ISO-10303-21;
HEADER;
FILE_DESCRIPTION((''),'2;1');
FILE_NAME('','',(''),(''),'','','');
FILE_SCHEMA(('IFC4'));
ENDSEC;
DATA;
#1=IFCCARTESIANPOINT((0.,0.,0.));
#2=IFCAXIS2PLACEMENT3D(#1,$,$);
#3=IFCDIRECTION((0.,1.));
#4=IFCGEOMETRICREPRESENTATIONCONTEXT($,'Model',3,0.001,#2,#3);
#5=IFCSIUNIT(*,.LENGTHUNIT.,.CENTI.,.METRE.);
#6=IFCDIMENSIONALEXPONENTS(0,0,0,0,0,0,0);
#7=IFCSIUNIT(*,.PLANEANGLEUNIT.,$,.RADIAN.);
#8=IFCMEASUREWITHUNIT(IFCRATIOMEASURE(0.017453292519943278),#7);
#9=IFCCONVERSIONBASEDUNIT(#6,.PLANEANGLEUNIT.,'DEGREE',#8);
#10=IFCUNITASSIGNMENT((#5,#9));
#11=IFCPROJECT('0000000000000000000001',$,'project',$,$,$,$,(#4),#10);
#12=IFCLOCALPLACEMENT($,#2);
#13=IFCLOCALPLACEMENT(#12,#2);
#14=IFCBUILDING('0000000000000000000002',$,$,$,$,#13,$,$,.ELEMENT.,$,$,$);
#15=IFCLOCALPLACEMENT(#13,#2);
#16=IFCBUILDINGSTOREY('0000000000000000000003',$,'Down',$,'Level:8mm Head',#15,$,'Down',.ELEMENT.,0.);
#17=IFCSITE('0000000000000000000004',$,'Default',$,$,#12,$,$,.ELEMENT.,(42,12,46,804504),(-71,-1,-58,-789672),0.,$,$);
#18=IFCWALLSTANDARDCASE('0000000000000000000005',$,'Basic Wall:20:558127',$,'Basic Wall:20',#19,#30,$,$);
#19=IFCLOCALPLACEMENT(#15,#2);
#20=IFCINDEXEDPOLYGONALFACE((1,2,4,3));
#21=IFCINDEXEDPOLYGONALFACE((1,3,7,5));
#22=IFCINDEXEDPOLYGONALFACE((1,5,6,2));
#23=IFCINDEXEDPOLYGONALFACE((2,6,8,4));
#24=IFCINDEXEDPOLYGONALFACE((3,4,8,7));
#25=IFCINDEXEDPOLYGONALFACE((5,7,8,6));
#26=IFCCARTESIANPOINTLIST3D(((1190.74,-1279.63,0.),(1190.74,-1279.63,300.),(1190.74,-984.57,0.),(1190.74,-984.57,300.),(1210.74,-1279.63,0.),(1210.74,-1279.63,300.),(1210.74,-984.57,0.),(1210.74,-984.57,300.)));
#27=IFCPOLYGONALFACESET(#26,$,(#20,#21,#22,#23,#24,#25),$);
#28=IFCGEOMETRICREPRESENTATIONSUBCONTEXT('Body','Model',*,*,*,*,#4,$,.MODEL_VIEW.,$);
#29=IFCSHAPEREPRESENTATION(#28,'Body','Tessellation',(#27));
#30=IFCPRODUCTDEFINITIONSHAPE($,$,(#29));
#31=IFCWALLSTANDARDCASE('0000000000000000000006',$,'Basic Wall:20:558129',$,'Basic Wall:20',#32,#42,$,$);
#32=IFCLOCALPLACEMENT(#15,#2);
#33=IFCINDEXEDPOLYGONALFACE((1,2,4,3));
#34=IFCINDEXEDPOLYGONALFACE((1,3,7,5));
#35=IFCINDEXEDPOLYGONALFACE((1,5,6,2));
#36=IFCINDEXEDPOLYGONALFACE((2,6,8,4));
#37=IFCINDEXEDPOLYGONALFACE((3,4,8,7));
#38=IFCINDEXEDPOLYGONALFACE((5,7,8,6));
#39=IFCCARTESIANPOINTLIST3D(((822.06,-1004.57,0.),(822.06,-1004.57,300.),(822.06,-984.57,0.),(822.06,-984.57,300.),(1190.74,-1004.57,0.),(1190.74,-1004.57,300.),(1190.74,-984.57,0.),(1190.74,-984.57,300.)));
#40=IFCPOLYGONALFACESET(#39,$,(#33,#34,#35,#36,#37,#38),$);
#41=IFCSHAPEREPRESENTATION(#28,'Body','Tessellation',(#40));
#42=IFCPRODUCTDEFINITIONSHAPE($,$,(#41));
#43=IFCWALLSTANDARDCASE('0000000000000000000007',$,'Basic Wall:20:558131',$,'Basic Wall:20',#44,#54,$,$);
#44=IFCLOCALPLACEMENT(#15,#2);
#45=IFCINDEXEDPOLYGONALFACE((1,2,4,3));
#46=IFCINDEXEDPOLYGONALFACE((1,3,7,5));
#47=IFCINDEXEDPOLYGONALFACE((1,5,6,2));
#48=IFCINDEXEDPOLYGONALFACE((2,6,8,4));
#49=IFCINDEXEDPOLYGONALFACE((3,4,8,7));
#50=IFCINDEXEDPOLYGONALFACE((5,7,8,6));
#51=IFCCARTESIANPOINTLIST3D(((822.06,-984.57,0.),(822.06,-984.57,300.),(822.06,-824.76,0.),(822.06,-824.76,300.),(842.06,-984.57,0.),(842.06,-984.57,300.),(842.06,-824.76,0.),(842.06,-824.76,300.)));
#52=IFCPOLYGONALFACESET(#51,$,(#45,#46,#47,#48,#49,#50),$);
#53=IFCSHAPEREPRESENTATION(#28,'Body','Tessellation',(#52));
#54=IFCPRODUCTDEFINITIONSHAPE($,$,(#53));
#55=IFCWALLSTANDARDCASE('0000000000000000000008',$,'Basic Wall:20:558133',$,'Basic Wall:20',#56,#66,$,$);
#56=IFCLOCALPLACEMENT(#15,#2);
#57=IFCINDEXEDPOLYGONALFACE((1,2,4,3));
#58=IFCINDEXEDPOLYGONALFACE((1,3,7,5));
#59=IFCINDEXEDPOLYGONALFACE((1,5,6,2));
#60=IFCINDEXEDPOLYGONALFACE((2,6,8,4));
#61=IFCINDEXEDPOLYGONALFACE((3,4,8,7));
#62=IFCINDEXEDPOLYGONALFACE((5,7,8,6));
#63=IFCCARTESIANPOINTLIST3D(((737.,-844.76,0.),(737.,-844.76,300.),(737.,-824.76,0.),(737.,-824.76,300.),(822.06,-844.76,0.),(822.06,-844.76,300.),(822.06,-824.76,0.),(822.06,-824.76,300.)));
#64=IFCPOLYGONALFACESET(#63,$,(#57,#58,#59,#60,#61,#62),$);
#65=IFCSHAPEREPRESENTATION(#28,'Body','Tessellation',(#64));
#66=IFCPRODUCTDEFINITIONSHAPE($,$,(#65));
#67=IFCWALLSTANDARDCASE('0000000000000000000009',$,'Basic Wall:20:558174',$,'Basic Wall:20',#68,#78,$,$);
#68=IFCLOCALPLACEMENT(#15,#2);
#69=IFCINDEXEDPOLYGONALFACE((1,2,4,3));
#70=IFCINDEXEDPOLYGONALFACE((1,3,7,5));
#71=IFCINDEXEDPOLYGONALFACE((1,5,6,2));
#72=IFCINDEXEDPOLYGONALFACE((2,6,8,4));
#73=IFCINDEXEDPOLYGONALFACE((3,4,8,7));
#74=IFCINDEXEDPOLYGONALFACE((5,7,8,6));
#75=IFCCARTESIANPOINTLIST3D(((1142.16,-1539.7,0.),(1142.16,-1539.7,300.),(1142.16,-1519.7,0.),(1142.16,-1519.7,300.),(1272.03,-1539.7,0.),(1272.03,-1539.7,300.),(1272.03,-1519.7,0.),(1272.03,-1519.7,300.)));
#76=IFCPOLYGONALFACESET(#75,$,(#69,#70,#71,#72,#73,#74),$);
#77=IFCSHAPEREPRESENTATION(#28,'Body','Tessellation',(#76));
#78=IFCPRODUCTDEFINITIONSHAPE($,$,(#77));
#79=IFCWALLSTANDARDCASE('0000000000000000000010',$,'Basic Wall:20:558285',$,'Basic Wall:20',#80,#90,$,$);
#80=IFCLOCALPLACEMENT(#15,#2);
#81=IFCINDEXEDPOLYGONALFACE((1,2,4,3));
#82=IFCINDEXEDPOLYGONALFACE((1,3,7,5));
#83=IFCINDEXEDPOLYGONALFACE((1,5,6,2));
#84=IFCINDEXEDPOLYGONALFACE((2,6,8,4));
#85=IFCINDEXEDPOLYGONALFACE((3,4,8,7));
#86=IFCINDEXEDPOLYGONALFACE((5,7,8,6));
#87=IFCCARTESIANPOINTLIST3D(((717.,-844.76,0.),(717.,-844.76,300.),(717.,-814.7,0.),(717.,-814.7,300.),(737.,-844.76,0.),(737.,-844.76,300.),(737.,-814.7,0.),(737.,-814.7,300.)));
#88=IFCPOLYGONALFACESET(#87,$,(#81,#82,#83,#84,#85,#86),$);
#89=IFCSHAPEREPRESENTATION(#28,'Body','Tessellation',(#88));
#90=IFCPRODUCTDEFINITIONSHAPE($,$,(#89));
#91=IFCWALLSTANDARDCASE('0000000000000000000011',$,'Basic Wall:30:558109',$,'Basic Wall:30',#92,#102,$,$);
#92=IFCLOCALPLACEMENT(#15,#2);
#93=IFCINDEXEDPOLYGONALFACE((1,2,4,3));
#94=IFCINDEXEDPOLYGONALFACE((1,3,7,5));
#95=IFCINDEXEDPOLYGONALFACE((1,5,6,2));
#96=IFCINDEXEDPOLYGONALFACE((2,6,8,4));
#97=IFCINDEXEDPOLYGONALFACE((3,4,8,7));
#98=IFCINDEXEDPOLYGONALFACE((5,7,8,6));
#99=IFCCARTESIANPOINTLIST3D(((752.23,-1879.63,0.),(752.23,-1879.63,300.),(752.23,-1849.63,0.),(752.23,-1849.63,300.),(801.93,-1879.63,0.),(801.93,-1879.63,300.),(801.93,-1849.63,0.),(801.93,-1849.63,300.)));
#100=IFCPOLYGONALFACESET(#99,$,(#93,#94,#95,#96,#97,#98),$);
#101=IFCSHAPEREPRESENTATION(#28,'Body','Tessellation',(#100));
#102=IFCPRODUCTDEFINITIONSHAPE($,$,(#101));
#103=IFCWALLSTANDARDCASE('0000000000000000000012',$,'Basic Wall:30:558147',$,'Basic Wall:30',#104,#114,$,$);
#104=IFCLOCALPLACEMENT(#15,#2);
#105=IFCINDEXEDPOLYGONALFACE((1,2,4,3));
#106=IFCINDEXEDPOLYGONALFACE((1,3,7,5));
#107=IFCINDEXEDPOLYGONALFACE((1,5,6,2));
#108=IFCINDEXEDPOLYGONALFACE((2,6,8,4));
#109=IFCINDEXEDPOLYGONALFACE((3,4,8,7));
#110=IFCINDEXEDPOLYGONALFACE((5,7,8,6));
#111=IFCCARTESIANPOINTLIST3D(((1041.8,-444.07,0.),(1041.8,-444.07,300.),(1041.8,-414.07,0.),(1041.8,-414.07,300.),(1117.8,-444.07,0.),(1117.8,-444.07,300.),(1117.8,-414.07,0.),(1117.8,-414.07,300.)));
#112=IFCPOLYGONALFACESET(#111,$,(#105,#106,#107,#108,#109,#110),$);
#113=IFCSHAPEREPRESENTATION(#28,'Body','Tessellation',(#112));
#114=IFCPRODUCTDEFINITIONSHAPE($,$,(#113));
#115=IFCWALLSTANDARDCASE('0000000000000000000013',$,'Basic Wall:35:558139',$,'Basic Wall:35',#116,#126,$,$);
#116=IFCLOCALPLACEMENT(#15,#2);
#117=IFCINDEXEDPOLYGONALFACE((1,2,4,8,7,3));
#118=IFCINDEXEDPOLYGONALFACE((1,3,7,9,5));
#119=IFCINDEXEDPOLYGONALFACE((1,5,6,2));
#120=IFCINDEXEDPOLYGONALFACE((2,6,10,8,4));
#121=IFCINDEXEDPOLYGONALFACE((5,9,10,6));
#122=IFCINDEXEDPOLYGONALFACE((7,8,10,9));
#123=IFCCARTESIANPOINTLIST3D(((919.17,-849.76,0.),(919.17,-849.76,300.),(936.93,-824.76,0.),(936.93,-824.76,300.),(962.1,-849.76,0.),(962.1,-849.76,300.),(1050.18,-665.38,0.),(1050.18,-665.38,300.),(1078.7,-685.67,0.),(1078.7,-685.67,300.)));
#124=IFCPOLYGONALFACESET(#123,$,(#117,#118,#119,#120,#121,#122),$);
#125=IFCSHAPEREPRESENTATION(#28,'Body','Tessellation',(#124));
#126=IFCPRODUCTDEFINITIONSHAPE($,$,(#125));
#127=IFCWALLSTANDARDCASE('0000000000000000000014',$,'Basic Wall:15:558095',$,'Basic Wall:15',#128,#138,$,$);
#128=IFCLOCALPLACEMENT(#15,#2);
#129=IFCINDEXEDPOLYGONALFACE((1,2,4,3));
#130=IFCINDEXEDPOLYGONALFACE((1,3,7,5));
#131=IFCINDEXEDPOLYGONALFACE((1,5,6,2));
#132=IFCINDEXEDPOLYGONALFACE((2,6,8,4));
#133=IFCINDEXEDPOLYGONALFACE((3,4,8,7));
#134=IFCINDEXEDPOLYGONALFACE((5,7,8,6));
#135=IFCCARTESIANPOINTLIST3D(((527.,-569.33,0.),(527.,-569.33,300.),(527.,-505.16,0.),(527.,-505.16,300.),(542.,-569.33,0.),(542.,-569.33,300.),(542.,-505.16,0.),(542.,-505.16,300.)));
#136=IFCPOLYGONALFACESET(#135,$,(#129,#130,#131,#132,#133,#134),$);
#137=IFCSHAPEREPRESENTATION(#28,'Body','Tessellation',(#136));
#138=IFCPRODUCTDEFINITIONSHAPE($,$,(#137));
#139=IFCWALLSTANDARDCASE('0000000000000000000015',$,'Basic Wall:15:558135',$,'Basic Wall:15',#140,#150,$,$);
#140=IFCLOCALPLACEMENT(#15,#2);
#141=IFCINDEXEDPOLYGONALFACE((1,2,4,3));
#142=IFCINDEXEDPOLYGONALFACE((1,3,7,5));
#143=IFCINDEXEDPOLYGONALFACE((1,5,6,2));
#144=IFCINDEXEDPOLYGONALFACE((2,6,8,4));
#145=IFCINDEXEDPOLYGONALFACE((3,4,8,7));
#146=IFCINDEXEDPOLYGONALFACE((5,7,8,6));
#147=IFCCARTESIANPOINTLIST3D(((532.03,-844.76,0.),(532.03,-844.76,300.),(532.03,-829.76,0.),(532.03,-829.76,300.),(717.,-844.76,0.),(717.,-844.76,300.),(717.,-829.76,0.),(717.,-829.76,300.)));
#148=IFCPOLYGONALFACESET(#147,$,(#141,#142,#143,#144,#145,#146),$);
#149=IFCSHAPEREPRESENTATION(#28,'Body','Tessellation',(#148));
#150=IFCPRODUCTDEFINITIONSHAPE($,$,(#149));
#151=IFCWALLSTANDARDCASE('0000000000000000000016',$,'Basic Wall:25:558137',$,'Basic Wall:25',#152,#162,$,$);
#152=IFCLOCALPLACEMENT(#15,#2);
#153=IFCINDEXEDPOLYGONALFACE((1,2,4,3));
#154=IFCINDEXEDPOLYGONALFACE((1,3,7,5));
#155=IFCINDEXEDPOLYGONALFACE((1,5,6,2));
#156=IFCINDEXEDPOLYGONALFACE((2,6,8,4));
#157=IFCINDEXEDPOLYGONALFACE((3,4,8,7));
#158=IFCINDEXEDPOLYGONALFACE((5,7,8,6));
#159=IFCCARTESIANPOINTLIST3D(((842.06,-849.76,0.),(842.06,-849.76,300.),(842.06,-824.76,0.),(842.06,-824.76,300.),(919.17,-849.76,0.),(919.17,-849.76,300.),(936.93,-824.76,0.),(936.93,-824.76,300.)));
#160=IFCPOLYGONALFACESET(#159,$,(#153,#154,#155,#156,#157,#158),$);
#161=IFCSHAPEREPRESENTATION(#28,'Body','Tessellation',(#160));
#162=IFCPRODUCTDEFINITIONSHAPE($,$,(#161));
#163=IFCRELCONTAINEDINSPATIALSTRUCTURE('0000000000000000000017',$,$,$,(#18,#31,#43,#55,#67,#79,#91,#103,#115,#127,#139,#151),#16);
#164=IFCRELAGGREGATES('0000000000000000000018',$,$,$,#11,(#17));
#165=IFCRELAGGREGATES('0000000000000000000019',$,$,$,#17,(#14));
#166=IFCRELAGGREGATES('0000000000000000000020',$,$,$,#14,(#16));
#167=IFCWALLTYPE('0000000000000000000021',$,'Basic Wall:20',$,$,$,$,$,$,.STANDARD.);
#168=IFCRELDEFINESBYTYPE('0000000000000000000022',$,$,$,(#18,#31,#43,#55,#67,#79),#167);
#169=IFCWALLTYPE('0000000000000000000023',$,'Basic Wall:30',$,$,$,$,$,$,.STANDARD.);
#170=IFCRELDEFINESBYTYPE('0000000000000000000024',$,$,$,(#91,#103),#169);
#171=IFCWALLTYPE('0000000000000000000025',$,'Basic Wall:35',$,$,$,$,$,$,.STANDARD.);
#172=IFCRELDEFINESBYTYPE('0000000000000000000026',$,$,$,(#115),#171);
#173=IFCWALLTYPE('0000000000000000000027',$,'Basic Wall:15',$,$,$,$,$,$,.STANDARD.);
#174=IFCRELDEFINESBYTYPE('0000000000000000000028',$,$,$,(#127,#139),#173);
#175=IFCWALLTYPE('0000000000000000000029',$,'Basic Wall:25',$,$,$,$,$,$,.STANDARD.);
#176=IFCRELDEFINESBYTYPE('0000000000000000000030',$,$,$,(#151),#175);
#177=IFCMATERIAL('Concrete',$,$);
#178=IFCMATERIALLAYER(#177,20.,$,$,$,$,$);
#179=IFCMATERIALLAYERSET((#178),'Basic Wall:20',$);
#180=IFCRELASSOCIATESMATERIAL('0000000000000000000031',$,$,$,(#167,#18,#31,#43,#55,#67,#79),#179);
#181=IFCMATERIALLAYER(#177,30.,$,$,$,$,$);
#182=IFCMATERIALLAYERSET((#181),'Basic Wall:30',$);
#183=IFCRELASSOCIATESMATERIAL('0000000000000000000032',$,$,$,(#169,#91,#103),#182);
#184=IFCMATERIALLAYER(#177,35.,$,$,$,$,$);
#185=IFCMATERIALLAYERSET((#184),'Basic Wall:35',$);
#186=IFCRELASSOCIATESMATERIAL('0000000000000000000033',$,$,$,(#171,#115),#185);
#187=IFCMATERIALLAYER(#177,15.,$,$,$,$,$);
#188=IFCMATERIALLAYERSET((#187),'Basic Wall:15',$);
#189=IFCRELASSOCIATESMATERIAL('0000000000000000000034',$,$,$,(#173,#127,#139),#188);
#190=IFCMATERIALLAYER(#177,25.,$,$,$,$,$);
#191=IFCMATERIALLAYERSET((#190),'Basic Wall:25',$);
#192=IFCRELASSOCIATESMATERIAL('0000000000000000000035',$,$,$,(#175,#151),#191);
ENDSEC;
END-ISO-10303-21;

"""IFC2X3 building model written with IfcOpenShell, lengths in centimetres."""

from ifc_helpers import new_model, entity, si_unit, converted_unit, direction, frame, frame_2d, origin, place, context, subcontext, project, spatial, polyline, rectangle, outline, extrude, clip, bounded_halfspace, material, layer, layer_set, layer_usage, type_object, element, save


model = new_model("IFC2X3")

# Units and contexts
model_context = context("Model", 3, precision=0.001, world=origin(), true_north=direction((0.0, 1.0)))
body_context = subcontext(model_context, "Body", "Model", "MODEL_VIEW")
ifc_project = project(units=[si_unit("LENGTHUNIT", "METRE", prefix="CENTI"), converted_unit("PLANEANGLEUNIT", "DEGREE", entity("IfcRatioMeasure", 0.017453292519943278), si_unit("PLANEANGLEUNIT", "RADIAN"), dimensions=[0, 0, 0, 0, 0, 0, 0])], contexts=[model_context])

# Site, building, storey
site_placement = place(None, origin())
site = spatial("IfcSite", under=ifc_project, at=site_placement, Name="Default", CompositionType="ELEMENT", RefLatitude=(42, 12, 46, 804504), RefLongitude=(-71, -1, -58, -789672), RefElevation=0.0)
building_placement = place(site_placement, origin())
building = spatial("IfcBuilding", under=site, at=building_placement, CompositionType="ELEMENT")
storey_placement = place(building_placement, origin())
storey = spatial("IfcBuildingStorey", under=building, at=storey_placement, Name="Down", ObjectType="Level:8mm Head", LongName="Down", CompositionType="ELEMENT", Elevation=0.0)

# Walls
ifc_material = material(Name="Concrete")
ifc_layer_1 = layer(ifc_material, 20.0)
ifc_layer_set_1 = layer_set([ifc_layer_1], Name="Basic Wall:20")
wall_type_1 = type_object("IfcWallType", Name="Basic Wall:20", PredefinedType="STANDARD", material=ifc_layer_set_1)
ifc_layer_usage_1 = layer_usage(ifc_layer_set_1, "AXIS2", "NEGATIVE", 10.0)
wall_1_placement = place(storey_placement, frame((1200.74, -1279.63, 0.0), z_axis=(0.0, 0.0, 1.0), x_axis=(0.0, 1.0, 0.0)))
element("IfcWallStandardCase", 1, at=wall_1_placement, inside=storey, type_object=wall_type_1, material=ifc_layer_usage_1, Name="Basic Wall:20:558127", ObjectType="Basic Wall:20", context=body_context, shape_type="SweptSolid", body=[
    extrude(rectangle(XDim=295.07, YDim=20.0, at=frame_2d((147.53, 0.0), x_axis=(-1.0, 0.0))), origin(), (0.0, 0.0, 1.0), 300.0),
])
ifc_layer_usage_2 = layer_usage(ifc_layer_set_1, "AXIS2", "POSITIVE", -10.0)
wall_2_placement = place(storey_placement, frame((1190.74, -994.57, 0.0), z_axis=(0.0, 0.0, 1.0), x_axis=(-1.0, 0.0, 0.0)))
element("IfcWallStandardCase", 2, at=wall_2_placement, inside=storey, type_object=wall_type_1, material=ifc_layer_usage_2, Name="Basic Wall:20:558129", ObjectType="Basic Wall:20", context=body_context, shape_type="SweptSolid", body=[
    extrude(rectangle(XDim=368.68, YDim=20.0, at=frame_2d((184.34, 0.0), x_axis=(-1.0, 0.0))), origin(), (0.0, 0.0, 1.0), 300.0),
])
ifc_layer_usage_3 = layer_usage(ifc_layer_set_1, "AXIS2", "NEGATIVE", 10.0)
wall_3_placement = place(storey_placement, frame((832.06, -984.57, 0.0), z_axis=(0.0, 0.0, 1.0), x_axis=(0.0, 1.0, 0.0)))
element("IfcWallStandardCase", 3, at=wall_3_placement, inside=storey, type_object=wall_type_1, material=ifc_layer_usage_3, Name="Basic Wall:20:558131", ObjectType="Basic Wall:20", context=body_context, shape_type="SweptSolid", body=[
    extrude(rectangle(XDim=159.8, YDim=20.0, at=frame_2d((79.9, 0.0), x_axis=(-1.0, 0.0))), origin(), (0.0, 0.0, 1.0), 300.0),
])
ifc_layer_usage_4 = layer_usage(ifc_layer_set_1, "AXIS2", "NEGATIVE", 10.0)
wall_4_placement = place(storey_placement, frame((822.06, -834.76, 0.0), z_axis=(0.0, 0.0, 1.0), x_axis=(-1.0, 0.0, 0.0)))
element("IfcWallStandardCase", 4, at=wall_4_placement, inside=storey, type_object=wall_type_1, material=ifc_layer_usage_4, Name="Basic Wall:20:558133", ObjectType="Basic Wall:20", context=body_context, shape_type="SweptSolid", body=[
    extrude(rectangle(XDim=85.07, YDim=20.0, at=frame_2d((42.53, 0.0), x_axis=(-1.0, 0.0))), origin(), (0.0, 0.0, 1.0), 300.0),
])
ifc_layer_usage_5 = layer_usage(ifc_layer_set_1, "AXIS2", "NEGATIVE", 10.0)
wall_5_placement = place(storey_placement, frame((1272.03, -1529.7, 0.0), z_axis=(0.0, 0.0, 1.0), x_axis=(-1.0, 0.0, 0.0)))
element("IfcWallStandardCase", 5, at=wall_5_placement, inside=storey, type_object=wall_type_1, material=ifc_layer_usage_5, Name="Basic Wall:20:558174", ObjectType="Basic Wall:20", context=body_context, shape_type="Clipping", body=[
    clip(extrude(rectangle(XDim=129.87, YDim=20.0, at=frame_2d((64.93, 0.0), x_axis=(-1.0, 0.0))), origin(), (0.0, 0.0, 1.0), 300.0), bounded_halfspace(frame((0.0, -10.0, 0.0), z_axis=(-1.0, 0.0, 0.0), x_axis=(0.0, 0.0, -1.0)), False, frame((0.0, -10.0, 0.0), z_axis=(-1.0, 0.0, 0.0), x_axis=(0.0, 0.0, -1.0)), polyline([(0.0, 0.0), (-280.0, 0.0), (-300.0, 0.0), (-300.0, -20.0), (0.0, -20.0), (0.0, 0.0)]))),
])
ifc_layer_usage_6 = layer_usage(ifc_layer_set_1, "AXIS2", "POSITIVE", -10.0)
wall_6_placement = place(storey_placement, frame((727.0, -814.7, 0.0), z_axis=(0.0, 0.0, 1.0), x_axis=(0.0, -1.0, 0.0)))
element("IfcWallStandardCase", 6, at=wall_6_placement, inside=storey, type_object=wall_type_1, material=ifc_layer_usage_6, Name="Basic Wall:20:558285", ObjectType="Basic Wall:20", context=body_context, shape_type="SweptSolid", body=[
    extrude(rectangle(XDim=30.07, YDim=20.0, at=frame_2d((15.03, 0.0), x_axis=(-1.0, 0.0))), origin(), (0.0, 0.0, 1.0), 300.0),
])
ifc_layer_2 = layer(ifc_material, 30.0)
ifc_layer_set_2 = layer_set([ifc_layer_2], Name="Basic Wall:30")
ifc_layer_usage_7 = layer_usage(ifc_layer_set_2, "AXIS2", "NEGATIVE", 15.0)
wall_type_2 = type_object("IfcWallType", Name="Basic Wall:30", PredefinedType="STANDARD", material=ifc_layer_set_2)
wall_7_placement = place(storey_placement, frame((752.23, -1864.63, 0.0)))
element("IfcWallStandardCase", 7, at=wall_7_placement, inside=storey, type_object=wall_type_2, material=ifc_layer_usage_7, Name="Basic Wall:30:558109", ObjectType="Basic Wall:30", context=body_context, shape_type="SweptSolid", body=[
    extrude(rectangle(XDim=49.7, YDim=30.0, at=frame_2d((24.85, 0.0), x_axis=(-1.0, 0.0))), origin(), (0.0, 0.0, 1.0), 300.0),
])
ifc_layer_usage_8 = layer_usage(ifc_layer_set_2, "AXIS2", "NEGATIVE", 15.0)
wall_8_placement = place(storey_placement, frame((1041.8, -429.07, 0.0)))
element("IfcWallStandardCase", 8, at=wall_8_placement, inside=storey, type_object=wall_type_2, material=ifc_layer_usage_8, Name="Basic Wall:30:558147", ObjectType="Basic Wall:30", context=body_context, shape_type="SweptSolid", body=[
    extrude(rectangle(XDim=76.0, YDim=30.0, at=frame_2d((38.0, 0.0), x_axis=(-1.0, 0.0))), origin(), (0.0, 0.0, 1.0), 300.0),
])
ifc_layer_3 = layer(ifc_material, 35.0)
ifc_layer_set_3 = layer_set([ifc_layer_3], Name="Basic Wall:35")
ifc_layer_usage_9 = layer_usage(ifc_layer_set_3, "AXIS2", "POSITIVE", -17.5)
wall_type_3 = type_object("IfcWallType", Name="Basic Wall:35", PredefinedType="STANDARD", material=ifc_layer_set_3)
wall_9_placement = place(storey_placement, frame((933.43, -859.9, 0.0), z_axis=(0.0, 0.0, 1.0), x_axis=(0.579207, 0.81518, 0.0)))
element("IfcWallStandardCase", 9, at=wall_9_placement, inside=storey, type_object=wall_type_3, material=ifc_layer_usage_9, Name="Basic Wall:35:558139", ObjectType="Basic Wall:35", context=body_context, shape_type="SweptSolid", body=[
    extrude(outline(polyline([(226.17, -17.5), (226.19, 17.5), (30.67, 17.5), (0.0, 17.5), (24.87, -17.5), (226.17, -17.5)])), origin(), (0.0, 0.0, 1.0), 300.0),
])
ifc_layer_4 = layer(ifc_material, 15.0)
ifc_layer_set_4 = layer_set([ifc_layer_4], Name="Basic Wall:15")
ifc_layer_usage_10 = layer_usage(ifc_layer_set_4, "AXIS2", "NEGATIVE", 7.5)
wall_type_4 = type_object("IfcWallType", Name="Basic Wall:15", PredefinedType="STANDARD", material=ifc_layer_set_4)
wall_10_placement = place(storey_placement, frame((534.5, -569.33, 0.0), z_axis=(0.0, 0.0, 1.0), x_axis=(0.0, 1.0, 0.0)))
element("IfcWallStandardCase", 10, at=wall_10_placement, inside=storey, type_object=wall_type_4, material=ifc_layer_usage_10, Name="Basic Wall:15:558095", ObjectType="Basic Wall:15", context=body_context, shape_type="SweptSolid", body=[
    extrude(rectangle(XDim=64.17, YDim=15.0, at=frame_2d((32.09, 0.0), x_axis=(-1.0, 0.0))), origin(), (0.0, 0.0, 1.0), 300.0),
])
ifc_layer_usage_11 = layer_usage(ifc_layer_set_4, "AXIS2", "NEGATIVE", 7.5)
wall_11_placement = place(storey_placement, frame((717.0, -837.26, 0.0), z_axis=(0.0, 0.0, 1.0), x_axis=(-1.0, 0.0, 0.0)))
element("IfcWallStandardCase", 11, at=wall_11_placement, inside=storey, type_object=wall_type_4, material=ifc_layer_usage_11, Name="Basic Wall:15:558135", ObjectType="Basic Wall:15", context=body_context, shape_type="SweptSolid", body=[
    extrude(rectangle(XDim=184.97, YDim=15.0, at=frame_2d((92.48, 0.0), x_axis=(-1.0, 0.0))), origin(), (0.0, 0.0, 1.0), 300.0),
])
ifc_layer_5 = layer(ifc_material, 25.0)
ifc_layer_set_5 = layer_set([ifc_layer_5], Name="Basic Wall:25")
ifc_layer_usage_12 = layer_usage(ifc_layer_set_5, "AXIS2", "NEGATIVE", 12.5)
wall_type_5 = type_object("IfcWallType", Name="Basic Wall:25", PredefinedType="STANDARD", material=ifc_layer_set_5)
wall_12_placement = place(storey_placement, frame((842.06, -837.26, 0.0)))
element("IfcWallStandardCase", 12, at=wall_12_placement, inside=storey, type_object=wall_type_5, material=ifc_layer_usage_12, Name="Basic Wall:25:558137", ObjectType="Basic Wall:25", context=body_context, shape_type="SweptSolid", body=[
    extrude(outline(polyline([(77.11, -12.5), (94.87, 12.5), (0.0, 12.5), (0.0, -12.5), (77.11, -12.5)])), origin(), (0.0, 0.0, 1.0), 300.0),
])

save(model, "model.ifc")
